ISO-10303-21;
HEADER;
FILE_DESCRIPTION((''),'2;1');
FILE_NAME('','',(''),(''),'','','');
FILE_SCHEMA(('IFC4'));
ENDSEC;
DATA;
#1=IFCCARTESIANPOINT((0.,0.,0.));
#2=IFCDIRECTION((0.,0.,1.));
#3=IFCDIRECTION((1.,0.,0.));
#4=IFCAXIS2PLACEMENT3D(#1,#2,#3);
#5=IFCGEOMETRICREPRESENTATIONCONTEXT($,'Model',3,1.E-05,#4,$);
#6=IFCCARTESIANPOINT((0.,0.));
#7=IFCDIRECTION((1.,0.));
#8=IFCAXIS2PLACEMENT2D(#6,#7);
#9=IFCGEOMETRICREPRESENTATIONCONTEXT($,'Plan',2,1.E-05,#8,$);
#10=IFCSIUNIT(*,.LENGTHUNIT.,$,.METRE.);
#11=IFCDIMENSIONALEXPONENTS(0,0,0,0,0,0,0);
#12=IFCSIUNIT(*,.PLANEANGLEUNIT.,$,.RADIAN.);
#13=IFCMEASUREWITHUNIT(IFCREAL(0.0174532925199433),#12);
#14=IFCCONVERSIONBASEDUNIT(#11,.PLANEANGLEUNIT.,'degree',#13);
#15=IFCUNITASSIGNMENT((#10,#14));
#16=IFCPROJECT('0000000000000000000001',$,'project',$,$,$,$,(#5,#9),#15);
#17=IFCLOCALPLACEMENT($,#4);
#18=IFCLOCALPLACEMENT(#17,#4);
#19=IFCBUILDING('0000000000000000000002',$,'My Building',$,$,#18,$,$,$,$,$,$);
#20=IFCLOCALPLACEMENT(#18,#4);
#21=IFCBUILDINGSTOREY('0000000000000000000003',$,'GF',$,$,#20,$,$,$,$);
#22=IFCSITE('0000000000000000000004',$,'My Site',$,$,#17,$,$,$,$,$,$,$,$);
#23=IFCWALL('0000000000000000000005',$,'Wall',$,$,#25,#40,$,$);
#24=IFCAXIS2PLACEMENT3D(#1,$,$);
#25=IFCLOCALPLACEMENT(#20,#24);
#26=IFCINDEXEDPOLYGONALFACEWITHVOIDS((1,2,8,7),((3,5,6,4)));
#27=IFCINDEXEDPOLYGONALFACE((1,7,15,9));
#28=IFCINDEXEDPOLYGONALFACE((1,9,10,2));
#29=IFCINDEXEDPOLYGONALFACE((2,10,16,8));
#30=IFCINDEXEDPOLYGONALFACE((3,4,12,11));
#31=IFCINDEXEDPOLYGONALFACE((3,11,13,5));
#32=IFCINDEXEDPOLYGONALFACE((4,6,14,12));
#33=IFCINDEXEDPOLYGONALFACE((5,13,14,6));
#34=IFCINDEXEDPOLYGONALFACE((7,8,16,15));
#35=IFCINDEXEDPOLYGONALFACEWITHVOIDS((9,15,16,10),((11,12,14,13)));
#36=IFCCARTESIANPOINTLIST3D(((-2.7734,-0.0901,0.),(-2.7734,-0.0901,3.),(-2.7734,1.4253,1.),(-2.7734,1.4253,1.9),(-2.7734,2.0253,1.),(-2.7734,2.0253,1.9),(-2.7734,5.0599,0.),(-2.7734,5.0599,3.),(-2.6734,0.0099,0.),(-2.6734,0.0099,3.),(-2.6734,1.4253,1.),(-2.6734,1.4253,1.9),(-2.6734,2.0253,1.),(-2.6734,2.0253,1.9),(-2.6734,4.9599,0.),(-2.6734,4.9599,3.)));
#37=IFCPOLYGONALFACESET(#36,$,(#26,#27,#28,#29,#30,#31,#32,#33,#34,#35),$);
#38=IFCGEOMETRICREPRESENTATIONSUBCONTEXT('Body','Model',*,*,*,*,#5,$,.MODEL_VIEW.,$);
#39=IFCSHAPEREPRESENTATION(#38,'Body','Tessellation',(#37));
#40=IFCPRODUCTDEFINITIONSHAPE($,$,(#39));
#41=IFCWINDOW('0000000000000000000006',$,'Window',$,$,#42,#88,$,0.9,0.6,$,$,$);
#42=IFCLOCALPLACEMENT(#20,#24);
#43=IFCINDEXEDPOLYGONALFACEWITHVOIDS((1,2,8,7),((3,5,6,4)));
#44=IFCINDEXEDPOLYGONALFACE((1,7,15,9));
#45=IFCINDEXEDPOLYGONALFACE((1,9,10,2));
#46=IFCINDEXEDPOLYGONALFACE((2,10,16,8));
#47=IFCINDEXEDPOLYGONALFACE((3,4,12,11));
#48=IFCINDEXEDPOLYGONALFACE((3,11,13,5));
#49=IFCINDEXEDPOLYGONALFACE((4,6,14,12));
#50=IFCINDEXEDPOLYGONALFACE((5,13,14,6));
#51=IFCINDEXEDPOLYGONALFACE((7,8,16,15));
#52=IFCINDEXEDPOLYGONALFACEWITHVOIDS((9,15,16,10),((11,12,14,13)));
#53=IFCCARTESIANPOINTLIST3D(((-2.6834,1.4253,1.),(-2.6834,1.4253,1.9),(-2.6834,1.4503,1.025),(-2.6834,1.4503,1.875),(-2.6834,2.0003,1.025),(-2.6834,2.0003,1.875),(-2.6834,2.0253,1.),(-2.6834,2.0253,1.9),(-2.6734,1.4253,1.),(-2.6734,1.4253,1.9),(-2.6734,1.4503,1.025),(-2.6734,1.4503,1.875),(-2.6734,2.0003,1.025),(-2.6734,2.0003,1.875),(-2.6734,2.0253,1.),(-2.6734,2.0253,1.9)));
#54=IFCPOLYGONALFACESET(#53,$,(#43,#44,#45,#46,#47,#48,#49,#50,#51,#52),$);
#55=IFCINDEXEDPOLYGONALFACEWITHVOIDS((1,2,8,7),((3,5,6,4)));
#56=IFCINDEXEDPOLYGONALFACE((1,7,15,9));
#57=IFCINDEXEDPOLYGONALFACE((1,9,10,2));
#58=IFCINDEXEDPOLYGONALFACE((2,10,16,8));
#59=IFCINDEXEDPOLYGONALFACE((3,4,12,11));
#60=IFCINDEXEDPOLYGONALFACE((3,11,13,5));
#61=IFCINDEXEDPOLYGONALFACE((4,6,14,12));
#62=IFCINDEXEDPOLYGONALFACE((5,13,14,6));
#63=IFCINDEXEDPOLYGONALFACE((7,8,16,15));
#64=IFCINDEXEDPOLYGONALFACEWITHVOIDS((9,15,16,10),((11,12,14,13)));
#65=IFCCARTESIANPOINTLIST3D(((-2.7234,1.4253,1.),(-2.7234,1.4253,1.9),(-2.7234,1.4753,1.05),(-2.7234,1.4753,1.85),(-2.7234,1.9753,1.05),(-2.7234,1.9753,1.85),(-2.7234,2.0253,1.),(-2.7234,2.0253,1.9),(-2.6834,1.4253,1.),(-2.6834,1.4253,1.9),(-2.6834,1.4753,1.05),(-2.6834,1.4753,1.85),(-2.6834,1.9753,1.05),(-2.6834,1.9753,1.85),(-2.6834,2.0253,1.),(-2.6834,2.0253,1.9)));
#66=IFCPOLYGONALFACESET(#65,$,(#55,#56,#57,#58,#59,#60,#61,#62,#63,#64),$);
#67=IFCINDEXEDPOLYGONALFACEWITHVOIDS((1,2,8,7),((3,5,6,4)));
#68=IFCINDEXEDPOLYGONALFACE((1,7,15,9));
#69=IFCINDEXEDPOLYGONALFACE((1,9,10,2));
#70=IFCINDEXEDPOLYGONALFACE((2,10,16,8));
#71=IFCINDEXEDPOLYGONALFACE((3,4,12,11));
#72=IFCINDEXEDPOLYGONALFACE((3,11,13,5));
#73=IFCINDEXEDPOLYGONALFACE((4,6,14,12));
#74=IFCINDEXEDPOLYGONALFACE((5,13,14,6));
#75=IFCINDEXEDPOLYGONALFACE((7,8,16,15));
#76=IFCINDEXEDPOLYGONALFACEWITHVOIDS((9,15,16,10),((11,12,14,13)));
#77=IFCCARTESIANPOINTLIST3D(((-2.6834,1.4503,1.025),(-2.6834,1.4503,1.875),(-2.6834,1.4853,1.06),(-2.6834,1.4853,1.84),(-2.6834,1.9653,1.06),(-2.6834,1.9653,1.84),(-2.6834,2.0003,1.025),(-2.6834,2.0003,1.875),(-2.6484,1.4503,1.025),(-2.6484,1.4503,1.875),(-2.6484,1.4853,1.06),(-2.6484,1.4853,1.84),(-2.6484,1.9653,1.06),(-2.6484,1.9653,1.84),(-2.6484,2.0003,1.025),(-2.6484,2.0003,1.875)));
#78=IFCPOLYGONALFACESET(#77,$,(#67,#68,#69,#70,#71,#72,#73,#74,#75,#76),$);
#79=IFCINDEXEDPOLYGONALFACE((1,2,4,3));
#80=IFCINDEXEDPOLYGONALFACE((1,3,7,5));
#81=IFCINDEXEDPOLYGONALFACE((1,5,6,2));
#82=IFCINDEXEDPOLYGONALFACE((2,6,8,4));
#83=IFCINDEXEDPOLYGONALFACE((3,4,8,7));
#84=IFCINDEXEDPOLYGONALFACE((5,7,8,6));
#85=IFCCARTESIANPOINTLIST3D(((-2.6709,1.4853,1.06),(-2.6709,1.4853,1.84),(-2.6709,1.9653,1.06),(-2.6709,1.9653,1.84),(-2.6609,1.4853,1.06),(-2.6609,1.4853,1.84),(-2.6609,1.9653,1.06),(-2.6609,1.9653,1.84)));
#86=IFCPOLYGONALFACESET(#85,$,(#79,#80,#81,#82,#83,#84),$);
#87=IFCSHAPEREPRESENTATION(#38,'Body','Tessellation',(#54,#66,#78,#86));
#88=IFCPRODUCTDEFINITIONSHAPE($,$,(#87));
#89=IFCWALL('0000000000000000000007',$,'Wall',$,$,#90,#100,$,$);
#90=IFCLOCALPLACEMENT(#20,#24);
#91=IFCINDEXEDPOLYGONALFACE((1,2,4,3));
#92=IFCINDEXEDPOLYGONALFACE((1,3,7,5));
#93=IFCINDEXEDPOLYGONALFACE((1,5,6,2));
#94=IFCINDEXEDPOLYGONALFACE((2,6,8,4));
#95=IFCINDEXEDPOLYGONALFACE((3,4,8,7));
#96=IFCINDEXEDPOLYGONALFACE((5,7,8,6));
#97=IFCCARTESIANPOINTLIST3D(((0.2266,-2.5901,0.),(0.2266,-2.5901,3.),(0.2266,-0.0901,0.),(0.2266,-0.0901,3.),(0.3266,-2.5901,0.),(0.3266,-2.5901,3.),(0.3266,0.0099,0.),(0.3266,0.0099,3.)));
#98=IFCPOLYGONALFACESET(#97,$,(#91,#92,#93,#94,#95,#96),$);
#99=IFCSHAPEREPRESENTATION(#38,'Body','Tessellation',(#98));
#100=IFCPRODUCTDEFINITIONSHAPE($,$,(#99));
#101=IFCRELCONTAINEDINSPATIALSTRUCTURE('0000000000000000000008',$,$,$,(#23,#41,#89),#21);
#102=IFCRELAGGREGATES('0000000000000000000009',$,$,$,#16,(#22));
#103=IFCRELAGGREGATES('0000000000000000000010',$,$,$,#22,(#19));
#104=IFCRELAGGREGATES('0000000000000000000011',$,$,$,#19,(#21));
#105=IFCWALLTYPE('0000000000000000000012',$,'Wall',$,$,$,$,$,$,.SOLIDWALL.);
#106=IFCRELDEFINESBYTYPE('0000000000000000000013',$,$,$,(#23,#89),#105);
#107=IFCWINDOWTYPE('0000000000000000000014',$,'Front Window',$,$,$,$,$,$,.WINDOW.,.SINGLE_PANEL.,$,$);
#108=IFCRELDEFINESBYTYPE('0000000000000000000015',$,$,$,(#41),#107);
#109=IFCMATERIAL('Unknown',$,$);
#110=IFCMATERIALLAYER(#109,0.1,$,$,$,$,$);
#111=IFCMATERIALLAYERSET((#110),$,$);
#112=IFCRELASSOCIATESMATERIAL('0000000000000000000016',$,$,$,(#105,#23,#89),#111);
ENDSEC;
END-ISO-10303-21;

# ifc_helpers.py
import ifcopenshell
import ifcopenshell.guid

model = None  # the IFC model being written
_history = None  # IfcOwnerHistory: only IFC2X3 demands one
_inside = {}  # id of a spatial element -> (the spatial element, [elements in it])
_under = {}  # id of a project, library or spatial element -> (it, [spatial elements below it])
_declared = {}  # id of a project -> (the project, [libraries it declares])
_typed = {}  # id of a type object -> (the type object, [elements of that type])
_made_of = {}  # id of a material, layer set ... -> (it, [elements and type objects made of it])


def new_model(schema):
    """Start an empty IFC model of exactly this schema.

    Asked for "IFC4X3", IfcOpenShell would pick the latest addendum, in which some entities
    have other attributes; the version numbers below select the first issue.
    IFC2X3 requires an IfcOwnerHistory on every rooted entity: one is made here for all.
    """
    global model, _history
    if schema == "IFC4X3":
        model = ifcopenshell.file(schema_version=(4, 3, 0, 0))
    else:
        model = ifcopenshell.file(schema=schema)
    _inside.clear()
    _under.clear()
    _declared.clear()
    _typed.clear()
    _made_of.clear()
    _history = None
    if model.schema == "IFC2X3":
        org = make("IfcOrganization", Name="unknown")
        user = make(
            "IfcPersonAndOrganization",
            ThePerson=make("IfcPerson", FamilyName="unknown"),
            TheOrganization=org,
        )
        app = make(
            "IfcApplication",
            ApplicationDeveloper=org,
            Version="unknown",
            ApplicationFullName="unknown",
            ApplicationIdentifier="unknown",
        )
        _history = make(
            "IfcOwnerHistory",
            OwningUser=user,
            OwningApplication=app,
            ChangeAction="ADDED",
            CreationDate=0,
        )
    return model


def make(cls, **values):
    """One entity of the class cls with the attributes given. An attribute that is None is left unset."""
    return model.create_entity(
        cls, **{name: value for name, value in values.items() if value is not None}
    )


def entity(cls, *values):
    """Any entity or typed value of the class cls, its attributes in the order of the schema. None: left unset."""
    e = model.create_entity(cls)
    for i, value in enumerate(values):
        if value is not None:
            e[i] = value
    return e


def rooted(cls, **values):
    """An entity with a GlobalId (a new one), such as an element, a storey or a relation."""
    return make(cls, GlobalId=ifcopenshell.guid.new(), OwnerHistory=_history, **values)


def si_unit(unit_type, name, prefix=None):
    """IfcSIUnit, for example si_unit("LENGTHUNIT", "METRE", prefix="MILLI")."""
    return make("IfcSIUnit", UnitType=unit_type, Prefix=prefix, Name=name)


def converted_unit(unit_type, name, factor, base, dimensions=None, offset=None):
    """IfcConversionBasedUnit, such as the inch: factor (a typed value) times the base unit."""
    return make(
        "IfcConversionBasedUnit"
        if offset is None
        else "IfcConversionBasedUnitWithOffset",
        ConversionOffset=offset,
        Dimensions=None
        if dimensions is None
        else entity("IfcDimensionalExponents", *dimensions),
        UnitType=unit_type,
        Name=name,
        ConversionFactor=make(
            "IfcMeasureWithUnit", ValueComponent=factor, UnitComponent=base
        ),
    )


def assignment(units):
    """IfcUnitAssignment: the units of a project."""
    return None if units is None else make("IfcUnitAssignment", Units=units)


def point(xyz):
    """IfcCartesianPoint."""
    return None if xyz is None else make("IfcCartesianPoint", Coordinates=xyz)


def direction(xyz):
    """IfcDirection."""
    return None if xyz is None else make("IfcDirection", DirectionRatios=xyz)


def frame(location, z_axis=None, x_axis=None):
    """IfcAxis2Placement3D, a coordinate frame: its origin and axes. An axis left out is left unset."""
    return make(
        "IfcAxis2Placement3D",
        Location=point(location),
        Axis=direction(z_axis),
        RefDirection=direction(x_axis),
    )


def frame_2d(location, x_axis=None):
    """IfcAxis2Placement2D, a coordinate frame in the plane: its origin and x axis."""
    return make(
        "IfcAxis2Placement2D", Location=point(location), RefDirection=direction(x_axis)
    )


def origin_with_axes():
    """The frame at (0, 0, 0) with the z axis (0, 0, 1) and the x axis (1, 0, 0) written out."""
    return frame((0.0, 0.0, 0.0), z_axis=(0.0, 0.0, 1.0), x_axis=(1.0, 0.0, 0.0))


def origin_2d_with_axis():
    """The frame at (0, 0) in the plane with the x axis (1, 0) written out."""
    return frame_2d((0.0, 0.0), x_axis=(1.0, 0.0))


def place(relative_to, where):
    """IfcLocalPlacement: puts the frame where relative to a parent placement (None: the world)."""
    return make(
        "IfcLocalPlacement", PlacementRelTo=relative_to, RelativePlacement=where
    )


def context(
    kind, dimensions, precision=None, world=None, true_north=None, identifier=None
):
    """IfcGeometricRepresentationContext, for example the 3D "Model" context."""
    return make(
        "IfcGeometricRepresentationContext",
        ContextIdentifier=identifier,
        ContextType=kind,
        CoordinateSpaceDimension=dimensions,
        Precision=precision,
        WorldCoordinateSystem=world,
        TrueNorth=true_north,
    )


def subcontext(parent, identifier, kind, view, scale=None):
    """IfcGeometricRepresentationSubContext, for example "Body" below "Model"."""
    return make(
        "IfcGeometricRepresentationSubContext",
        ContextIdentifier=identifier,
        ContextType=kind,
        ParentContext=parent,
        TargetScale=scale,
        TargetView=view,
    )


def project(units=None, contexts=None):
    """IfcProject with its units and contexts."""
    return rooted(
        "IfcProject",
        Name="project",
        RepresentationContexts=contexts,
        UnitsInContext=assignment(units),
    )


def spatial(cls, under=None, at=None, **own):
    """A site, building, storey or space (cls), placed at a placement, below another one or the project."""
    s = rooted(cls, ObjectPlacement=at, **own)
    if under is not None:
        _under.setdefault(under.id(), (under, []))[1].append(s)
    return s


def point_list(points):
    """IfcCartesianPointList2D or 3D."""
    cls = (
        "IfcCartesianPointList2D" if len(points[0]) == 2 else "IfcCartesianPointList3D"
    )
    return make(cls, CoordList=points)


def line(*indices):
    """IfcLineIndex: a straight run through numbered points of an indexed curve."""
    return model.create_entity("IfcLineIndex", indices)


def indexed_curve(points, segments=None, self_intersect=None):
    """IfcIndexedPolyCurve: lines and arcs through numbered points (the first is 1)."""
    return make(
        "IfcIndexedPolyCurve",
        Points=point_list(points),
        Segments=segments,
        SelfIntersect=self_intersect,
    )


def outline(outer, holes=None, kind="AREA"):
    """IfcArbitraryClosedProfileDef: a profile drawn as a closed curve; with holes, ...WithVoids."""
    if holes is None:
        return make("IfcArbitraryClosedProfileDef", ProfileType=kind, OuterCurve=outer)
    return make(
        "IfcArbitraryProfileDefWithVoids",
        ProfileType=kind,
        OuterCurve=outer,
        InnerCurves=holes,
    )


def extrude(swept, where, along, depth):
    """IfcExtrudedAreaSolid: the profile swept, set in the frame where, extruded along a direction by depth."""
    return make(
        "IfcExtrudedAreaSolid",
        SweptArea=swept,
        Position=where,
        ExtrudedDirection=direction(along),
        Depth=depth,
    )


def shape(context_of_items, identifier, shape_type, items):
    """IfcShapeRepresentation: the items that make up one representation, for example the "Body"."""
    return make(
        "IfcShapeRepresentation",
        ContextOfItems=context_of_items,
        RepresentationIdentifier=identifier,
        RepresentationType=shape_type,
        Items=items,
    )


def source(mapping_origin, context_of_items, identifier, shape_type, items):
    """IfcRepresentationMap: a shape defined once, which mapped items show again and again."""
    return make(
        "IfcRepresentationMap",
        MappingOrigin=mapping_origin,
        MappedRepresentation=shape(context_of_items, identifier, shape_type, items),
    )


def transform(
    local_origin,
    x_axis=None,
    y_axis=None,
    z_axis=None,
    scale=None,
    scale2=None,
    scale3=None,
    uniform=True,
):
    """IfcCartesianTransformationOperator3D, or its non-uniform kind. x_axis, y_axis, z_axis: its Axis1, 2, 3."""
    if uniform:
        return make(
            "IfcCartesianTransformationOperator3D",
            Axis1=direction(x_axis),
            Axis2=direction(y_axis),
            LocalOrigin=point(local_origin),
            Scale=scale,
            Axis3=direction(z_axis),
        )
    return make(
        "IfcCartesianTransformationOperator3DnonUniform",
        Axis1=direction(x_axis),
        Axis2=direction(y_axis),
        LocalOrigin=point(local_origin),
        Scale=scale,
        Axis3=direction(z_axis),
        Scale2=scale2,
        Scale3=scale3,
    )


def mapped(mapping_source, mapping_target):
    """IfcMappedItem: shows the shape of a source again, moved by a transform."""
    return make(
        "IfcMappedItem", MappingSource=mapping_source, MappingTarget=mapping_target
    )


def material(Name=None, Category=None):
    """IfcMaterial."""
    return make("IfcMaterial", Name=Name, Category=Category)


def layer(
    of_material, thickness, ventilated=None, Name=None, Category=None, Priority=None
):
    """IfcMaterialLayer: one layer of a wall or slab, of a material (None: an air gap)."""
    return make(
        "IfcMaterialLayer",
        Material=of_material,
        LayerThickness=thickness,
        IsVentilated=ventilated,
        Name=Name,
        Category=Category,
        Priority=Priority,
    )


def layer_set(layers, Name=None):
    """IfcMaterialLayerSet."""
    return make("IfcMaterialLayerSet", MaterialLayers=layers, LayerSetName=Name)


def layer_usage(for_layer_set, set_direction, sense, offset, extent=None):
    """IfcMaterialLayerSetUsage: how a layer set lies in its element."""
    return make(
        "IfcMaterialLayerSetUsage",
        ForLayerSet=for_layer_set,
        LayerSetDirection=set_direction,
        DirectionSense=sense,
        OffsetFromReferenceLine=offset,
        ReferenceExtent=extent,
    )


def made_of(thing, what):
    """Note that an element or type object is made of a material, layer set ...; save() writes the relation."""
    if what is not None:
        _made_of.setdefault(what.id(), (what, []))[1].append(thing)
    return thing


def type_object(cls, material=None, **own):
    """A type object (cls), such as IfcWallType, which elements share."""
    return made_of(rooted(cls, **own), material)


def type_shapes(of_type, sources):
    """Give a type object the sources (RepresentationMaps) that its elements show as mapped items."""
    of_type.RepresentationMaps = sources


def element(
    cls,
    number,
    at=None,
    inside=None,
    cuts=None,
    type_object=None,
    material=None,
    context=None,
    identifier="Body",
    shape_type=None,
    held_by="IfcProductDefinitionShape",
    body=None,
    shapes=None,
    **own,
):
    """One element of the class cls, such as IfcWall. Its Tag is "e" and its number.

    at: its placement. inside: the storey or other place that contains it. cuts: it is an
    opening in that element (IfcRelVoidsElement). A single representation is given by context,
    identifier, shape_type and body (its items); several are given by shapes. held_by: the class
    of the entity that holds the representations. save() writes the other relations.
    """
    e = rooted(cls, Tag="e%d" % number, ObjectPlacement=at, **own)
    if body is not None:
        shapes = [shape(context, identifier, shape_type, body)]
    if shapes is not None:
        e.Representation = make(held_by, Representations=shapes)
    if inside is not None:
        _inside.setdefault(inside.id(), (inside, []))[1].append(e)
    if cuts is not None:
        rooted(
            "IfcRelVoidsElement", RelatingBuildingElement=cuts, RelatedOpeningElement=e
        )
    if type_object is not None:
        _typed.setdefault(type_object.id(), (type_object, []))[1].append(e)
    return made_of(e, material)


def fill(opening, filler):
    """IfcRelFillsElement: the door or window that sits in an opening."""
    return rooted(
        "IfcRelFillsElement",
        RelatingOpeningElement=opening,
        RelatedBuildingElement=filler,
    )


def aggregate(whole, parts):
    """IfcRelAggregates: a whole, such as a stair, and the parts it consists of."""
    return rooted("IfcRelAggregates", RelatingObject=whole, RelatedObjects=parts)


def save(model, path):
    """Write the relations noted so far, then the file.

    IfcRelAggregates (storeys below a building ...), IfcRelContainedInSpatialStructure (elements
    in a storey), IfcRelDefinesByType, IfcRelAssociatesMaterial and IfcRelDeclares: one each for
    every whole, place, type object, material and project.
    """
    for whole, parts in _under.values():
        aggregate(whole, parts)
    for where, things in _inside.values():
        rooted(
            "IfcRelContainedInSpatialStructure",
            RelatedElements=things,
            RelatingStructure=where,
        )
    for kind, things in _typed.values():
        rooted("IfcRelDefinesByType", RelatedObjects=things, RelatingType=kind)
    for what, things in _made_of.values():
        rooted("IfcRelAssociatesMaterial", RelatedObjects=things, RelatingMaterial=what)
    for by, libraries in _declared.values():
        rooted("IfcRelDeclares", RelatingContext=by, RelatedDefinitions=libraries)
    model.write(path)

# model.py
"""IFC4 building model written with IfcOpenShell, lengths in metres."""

from ifc_helpers import new_model, entity, si_unit, converted_unit, frame, origin_with_axes, origin_2d_with_axis, place, context, subcontext, project, spatial, line, indexed_curve, outline, extrude, shape, source, transform, mapped, material, layer, layer_set, layer_usage, type_object, type_shapes, element, fill, save


model = new_model("IFC4")

# Units and contexts
model_context = context("Model", 3, precision=1e-05, world=origin_with_axes())
plan_context = context("Plan", 2, precision=1e-05, world=origin_2d_with_axis())
body_context_1 = subcontext(model_context, "Body", "Model", "MODEL_VIEW")
body_context_2 = subcontext(plan_context, "Body", "Plan", "PLAN_VIEW")
ifc_project = project(units=[si_unit("LENGTHUNIT", "METRE"), converted_unit("PLANEANGLEUNIT", "degree", entity("IfcReal", 0.0174532925199433), si_unit("PLANEANGLEUNIT", "RADIAN"), dimensions=[0, 0, 0, 0, 0, 0, 0])], contexts=[model_context, plan_context])

# Site, building, storey
site_placement = place(None, origin_with_axes())
site = spatial("IfcSite", under=ifc_project, at=site_placement, Name="My Site")
building_placement = place(site_placement, origin_with_axes())
building = spatial("IfcBuilding", under=site, at=building_placement, Name="My Building")
storey_placement = place(building_placement, origin_with_axes())
storey = spatial("IfcBuildingStorey", under=building, at=storey_placement, Name="GF")

# Shared definitions
ifc_material = material(Name="Unknown")

# Shared definitions
ifc_layer_1 = layer(ifc_material, 0.1)
ifc_layer_set_1 = layer_set([ifc_layer_1])
wall_type = type_object("IfcWallType", Name="Wall", PredefinedType="SOLIDWALL", material=ifc_layer_set_1)
shared_shape_1 = source(origin_with_axes(), body_context_1, "Body", "SweptSolid", [
    extrude(outline(indexed_curve([(0.0, 0.0), (0.6, 0.0), (0.6, 0.9), (0.0, 0.9)], segments=[line(1, 2, 3, 4, 1)])), frame((0.0, -0.6, 0.0), z_axis=(0.0, -1.0, 0.0), x_axis=(1.0, 0.0, 0.0)), (0.0, 0.0, -1.0), 1.2),
])
window_type_1 = type_object("IfcWindowType", Name="Front Window", PartitioningType="SINGLE_PANEL", PredefinedType="WINDOW")
shared_shape_2 = source(origin_with_axes(), body_context_1, "Body", "SweptSolid", [
    extrude(outline(indexed_curve([(0.0, 0.0), (0.6, 0.0), (0.6, 0.9), (0.0, 0.9)], segments=[line(1, 2, 3, 4, 1)]), holes=[indexed_curve([(0.025, 0.025), (0.575, 0.025), (0.575, 0.875), (0.025, 0.875)], segments=[line(1, 2, 3, 4, 1)])]), frame((0.0, 0.09, 0.0), z_axis=(0.0, -1.0, 0.0), x_axis=(1.0, 0.0, 0.0)), (0.0, 0.0, -1.0), 0.01),
    extrude(outline(indexed_curve([(0.0, 0.0), (0.6, 0.0), (0.6, 0.9), (0.0, 0.9)], segments=[line(1, 2, 3, 4, 1)]), holes=[indexed_curve([(0.05, 0.05), (0.55, 0.05), (0.55, 0.85), (0.05, 0.85)], segments=[line(1, 2, 3, 4, 1)])]), frame((0.0, 0.05, 0.0), z_axis=(0.0, -1.0, 0.0), x_axis=(1.0, 0.0, 0.0)), (0.0, 0.0, -1.0), 0.04),
    extrude(outline(indexed_curve([(0.0, 0.0), (0.55, 0.0), (0.55, 0.85), (0.0, 0.85)], segments=[line(1, 2, 3, 4, 1)]), holes=[indexed_curve([(0.035, 0.035), (0.515, 0.035), (0.515, 0.815), (0.035, 0.815)], segments=[line(1, 2, 3, 4, 1)])]), frame((0.025, 0.09, 0.025), z_axis=(0.0, -1.0, 0.0), x_axis=(1.0, 0.0, 0.0)), (0.0, 0.0, -1.0), 0.035),
    extrude(outline(indexed_curve([(0.035, 0.035), (0.515, 0.035), (0.515, 0.815), (0.035, 0.815)], segments=[line(1, 2, 3, 4, 1)])), frame((0.025, 0.1025, 0.025), z_axis=(0.0, -1.0, 0.0), x_axis=(1.0, 0.0, 0.0)), (0.0, 0.0, -1.0), 0.01),
])
shared_shape_3 = source(origin_with_axes(), body_context_2, "Body", "Curve2D", [
    entity("IfcIndexedPolyCurve", entity("IfcCartesianPointList2D", [[0.05, 0.05], [0.55, 0.05]])),
    entity("IfcIndexedPolyCurve", entity("IfcCartesianPointList2D", [[0.0, 0.1], [0.025, 0.1], [0.025, 0.09], [0.05, 0.09], [0.05, 0.05], [0.0, 0.05]]), [entity("IfcLineIndex", [1, 2, 3, 4, 5, 6, 1])]),
    entity("IfcIndexedPolyCurve", entity("IfcCartesianPointList2D", [[0.6, 0.1], [0.575, 0.1], [0.575, 0.09], [0.55, 0.09], [0.55, 0.05], [0.6, 0.05]]), [entity("IfcLineIndex", [1, 2, 3, 4, 5, 6, 1])]),
    entity("IfcIndexedPolyCurve", entity("IfcCartesianPointList2D", [[0.025, 0.09], [0.06, 0.09], [0.06, 0.125], [0.025, 0.125]]), [entity("IfcLineIndex", [1, 2, 3, 4, 1])]),
    entity("IfcIndexedPolyCurve", entity("IfcCartesianPointList2D", [[0.575, 0.09], [0.54, 0.09], [0.54, 0.125], [0.575, 0.125]]), [entity("IfcLineIndex", [1, 2, 3, 4, 1])]),
    entity("IfcIndexedPolyCurve", entity("IfcCartesianPointList2D", [[0.06, 0.09], [0.54, 0.09]])),
    entity("IfcIndexedPolyCurve", entity("IfcCartesianPointList2D", [[0.06, 0.125], [0.54, 0.125]])),
    entity("IfcIndexedPolyCurve", entity("IfcCartesianPointList2D", [[0.06, 0.1075], [0.54, 0.1075]])),
])
type_shapes(window_type_1, [shared_shape_2, shared_shape_3])

# Wall, opening, window
ifc_layer_usage_1 = layer_usage(ifc_layer_set_1, "AXIS2", "POSITIVE", 0.0)
wall_1_placement = place(storey_placement, frame((-2.7734, 5.0599, 0.0), z_axis=(0.0, 0.0, 1.0), x_axis=(0.0, -1.0, 0.0)))
wall_1 = element("IfcWall", 1, at=wall_1_placement, inside=storey, type_object=wall_type, material=ifc_layer_usage_1, Name="Wall", context=body_context_1, shape_type="SweptSolid", body=[
    extrude(outline(indexed_curve([(0.0, 0.0), (0.1, 0.1), (5.05, 0.1), (5.15, 0.0)], segments=[line(1, 2, 3, 4, 1)])), origin_with_axes(), (0.0, 0.0, 1.0), 3.0),
])
opening_1_placement = place(wall_1_placement, frame((3.0346, 0.0, 1.0), z_axis=(0.0, 0.0, 1.0), x_axis=(1.0, 0.0, 0.0)))
opening_1 = element("IfcOpeningElement", 2, at=opening_1_placement, cuts=wall_1, PredefinedType="OPENING", context=body_context_1, shape_type="MappedRepresentation", body=[
    mapped(shared_shape_1, transform((0.0, 0.0, 0.0), x_axis=(1.0, 0.0, 0.0), y_axis=(0.0, 1.0, 0.0), z_axis=(0.0, 0.0, 1.0), scale=1.0)),
])
window_1_placement = place(opening_1_placement, frame((0.0, 0.0, 0.0), z_axis=(0.0, 0.0, 1.0), x_axis=(1.0, 0.0, 0.0)))
window_1 = element("IfcWindow", 3, at=window_1_placement, inside=storey, type_object=window_type_1, Name="Window", OverallHeight=0.9, OverallWidth=0.6, shapes=[
    shape(body_context_1, "Body", "MappedRepresentation", [mapped(shared_shape_2, transform((0.0, 0.0, 0.0), x_axis=(1.0, 0.0, 0.0), y_axis=(0.0, 1.0, 0.0), z_axis=(0.0, 0.0, 1.0), scale=1.0))]),
    shape(body_context_2, "Body", "MappedRepresentation", [mapped(shared_shape_3, transform((0.0, 0.0, 0.0), x_axis=(1.0, 0.0, 0.0), y_axis=(0.0, 1.0, 0.0), z_axis=(0.0, 0.0, 1.0), scale=1.0))]),
])
fill(opening_1, window_1)

# Wall
ifc_layer_usage_2 = layer_usage(ifc_layer_set_1, "AXIS2", "POSITIVE", 0.0)
wall_2_placement = place(storey_placement, frame((0.2266, -0.0901, 0.0), z_axis=(0.0, 0.0, 1.0), x_axis=(0.0, -1.0, 0.0)))
element("IfcWall", 4, at=wall_2_placement, inside=storey, type_object=wall_type, material=ifc_layer_usage_2, Name="Wall", context=body_context_1, shape_type="SweptSolid", body=[
    extrude(outline(indexed_curve([(0.0, 0.0), (-0.1, 0.1), (2.5, 0.1), (2.5, 0.0)], segments=[line(1, 2, 3, 4, 1)])), origin_with_axes(), (0.0, 0.0, 1.0), 3.0),
])

save(model, "model.ifc")
